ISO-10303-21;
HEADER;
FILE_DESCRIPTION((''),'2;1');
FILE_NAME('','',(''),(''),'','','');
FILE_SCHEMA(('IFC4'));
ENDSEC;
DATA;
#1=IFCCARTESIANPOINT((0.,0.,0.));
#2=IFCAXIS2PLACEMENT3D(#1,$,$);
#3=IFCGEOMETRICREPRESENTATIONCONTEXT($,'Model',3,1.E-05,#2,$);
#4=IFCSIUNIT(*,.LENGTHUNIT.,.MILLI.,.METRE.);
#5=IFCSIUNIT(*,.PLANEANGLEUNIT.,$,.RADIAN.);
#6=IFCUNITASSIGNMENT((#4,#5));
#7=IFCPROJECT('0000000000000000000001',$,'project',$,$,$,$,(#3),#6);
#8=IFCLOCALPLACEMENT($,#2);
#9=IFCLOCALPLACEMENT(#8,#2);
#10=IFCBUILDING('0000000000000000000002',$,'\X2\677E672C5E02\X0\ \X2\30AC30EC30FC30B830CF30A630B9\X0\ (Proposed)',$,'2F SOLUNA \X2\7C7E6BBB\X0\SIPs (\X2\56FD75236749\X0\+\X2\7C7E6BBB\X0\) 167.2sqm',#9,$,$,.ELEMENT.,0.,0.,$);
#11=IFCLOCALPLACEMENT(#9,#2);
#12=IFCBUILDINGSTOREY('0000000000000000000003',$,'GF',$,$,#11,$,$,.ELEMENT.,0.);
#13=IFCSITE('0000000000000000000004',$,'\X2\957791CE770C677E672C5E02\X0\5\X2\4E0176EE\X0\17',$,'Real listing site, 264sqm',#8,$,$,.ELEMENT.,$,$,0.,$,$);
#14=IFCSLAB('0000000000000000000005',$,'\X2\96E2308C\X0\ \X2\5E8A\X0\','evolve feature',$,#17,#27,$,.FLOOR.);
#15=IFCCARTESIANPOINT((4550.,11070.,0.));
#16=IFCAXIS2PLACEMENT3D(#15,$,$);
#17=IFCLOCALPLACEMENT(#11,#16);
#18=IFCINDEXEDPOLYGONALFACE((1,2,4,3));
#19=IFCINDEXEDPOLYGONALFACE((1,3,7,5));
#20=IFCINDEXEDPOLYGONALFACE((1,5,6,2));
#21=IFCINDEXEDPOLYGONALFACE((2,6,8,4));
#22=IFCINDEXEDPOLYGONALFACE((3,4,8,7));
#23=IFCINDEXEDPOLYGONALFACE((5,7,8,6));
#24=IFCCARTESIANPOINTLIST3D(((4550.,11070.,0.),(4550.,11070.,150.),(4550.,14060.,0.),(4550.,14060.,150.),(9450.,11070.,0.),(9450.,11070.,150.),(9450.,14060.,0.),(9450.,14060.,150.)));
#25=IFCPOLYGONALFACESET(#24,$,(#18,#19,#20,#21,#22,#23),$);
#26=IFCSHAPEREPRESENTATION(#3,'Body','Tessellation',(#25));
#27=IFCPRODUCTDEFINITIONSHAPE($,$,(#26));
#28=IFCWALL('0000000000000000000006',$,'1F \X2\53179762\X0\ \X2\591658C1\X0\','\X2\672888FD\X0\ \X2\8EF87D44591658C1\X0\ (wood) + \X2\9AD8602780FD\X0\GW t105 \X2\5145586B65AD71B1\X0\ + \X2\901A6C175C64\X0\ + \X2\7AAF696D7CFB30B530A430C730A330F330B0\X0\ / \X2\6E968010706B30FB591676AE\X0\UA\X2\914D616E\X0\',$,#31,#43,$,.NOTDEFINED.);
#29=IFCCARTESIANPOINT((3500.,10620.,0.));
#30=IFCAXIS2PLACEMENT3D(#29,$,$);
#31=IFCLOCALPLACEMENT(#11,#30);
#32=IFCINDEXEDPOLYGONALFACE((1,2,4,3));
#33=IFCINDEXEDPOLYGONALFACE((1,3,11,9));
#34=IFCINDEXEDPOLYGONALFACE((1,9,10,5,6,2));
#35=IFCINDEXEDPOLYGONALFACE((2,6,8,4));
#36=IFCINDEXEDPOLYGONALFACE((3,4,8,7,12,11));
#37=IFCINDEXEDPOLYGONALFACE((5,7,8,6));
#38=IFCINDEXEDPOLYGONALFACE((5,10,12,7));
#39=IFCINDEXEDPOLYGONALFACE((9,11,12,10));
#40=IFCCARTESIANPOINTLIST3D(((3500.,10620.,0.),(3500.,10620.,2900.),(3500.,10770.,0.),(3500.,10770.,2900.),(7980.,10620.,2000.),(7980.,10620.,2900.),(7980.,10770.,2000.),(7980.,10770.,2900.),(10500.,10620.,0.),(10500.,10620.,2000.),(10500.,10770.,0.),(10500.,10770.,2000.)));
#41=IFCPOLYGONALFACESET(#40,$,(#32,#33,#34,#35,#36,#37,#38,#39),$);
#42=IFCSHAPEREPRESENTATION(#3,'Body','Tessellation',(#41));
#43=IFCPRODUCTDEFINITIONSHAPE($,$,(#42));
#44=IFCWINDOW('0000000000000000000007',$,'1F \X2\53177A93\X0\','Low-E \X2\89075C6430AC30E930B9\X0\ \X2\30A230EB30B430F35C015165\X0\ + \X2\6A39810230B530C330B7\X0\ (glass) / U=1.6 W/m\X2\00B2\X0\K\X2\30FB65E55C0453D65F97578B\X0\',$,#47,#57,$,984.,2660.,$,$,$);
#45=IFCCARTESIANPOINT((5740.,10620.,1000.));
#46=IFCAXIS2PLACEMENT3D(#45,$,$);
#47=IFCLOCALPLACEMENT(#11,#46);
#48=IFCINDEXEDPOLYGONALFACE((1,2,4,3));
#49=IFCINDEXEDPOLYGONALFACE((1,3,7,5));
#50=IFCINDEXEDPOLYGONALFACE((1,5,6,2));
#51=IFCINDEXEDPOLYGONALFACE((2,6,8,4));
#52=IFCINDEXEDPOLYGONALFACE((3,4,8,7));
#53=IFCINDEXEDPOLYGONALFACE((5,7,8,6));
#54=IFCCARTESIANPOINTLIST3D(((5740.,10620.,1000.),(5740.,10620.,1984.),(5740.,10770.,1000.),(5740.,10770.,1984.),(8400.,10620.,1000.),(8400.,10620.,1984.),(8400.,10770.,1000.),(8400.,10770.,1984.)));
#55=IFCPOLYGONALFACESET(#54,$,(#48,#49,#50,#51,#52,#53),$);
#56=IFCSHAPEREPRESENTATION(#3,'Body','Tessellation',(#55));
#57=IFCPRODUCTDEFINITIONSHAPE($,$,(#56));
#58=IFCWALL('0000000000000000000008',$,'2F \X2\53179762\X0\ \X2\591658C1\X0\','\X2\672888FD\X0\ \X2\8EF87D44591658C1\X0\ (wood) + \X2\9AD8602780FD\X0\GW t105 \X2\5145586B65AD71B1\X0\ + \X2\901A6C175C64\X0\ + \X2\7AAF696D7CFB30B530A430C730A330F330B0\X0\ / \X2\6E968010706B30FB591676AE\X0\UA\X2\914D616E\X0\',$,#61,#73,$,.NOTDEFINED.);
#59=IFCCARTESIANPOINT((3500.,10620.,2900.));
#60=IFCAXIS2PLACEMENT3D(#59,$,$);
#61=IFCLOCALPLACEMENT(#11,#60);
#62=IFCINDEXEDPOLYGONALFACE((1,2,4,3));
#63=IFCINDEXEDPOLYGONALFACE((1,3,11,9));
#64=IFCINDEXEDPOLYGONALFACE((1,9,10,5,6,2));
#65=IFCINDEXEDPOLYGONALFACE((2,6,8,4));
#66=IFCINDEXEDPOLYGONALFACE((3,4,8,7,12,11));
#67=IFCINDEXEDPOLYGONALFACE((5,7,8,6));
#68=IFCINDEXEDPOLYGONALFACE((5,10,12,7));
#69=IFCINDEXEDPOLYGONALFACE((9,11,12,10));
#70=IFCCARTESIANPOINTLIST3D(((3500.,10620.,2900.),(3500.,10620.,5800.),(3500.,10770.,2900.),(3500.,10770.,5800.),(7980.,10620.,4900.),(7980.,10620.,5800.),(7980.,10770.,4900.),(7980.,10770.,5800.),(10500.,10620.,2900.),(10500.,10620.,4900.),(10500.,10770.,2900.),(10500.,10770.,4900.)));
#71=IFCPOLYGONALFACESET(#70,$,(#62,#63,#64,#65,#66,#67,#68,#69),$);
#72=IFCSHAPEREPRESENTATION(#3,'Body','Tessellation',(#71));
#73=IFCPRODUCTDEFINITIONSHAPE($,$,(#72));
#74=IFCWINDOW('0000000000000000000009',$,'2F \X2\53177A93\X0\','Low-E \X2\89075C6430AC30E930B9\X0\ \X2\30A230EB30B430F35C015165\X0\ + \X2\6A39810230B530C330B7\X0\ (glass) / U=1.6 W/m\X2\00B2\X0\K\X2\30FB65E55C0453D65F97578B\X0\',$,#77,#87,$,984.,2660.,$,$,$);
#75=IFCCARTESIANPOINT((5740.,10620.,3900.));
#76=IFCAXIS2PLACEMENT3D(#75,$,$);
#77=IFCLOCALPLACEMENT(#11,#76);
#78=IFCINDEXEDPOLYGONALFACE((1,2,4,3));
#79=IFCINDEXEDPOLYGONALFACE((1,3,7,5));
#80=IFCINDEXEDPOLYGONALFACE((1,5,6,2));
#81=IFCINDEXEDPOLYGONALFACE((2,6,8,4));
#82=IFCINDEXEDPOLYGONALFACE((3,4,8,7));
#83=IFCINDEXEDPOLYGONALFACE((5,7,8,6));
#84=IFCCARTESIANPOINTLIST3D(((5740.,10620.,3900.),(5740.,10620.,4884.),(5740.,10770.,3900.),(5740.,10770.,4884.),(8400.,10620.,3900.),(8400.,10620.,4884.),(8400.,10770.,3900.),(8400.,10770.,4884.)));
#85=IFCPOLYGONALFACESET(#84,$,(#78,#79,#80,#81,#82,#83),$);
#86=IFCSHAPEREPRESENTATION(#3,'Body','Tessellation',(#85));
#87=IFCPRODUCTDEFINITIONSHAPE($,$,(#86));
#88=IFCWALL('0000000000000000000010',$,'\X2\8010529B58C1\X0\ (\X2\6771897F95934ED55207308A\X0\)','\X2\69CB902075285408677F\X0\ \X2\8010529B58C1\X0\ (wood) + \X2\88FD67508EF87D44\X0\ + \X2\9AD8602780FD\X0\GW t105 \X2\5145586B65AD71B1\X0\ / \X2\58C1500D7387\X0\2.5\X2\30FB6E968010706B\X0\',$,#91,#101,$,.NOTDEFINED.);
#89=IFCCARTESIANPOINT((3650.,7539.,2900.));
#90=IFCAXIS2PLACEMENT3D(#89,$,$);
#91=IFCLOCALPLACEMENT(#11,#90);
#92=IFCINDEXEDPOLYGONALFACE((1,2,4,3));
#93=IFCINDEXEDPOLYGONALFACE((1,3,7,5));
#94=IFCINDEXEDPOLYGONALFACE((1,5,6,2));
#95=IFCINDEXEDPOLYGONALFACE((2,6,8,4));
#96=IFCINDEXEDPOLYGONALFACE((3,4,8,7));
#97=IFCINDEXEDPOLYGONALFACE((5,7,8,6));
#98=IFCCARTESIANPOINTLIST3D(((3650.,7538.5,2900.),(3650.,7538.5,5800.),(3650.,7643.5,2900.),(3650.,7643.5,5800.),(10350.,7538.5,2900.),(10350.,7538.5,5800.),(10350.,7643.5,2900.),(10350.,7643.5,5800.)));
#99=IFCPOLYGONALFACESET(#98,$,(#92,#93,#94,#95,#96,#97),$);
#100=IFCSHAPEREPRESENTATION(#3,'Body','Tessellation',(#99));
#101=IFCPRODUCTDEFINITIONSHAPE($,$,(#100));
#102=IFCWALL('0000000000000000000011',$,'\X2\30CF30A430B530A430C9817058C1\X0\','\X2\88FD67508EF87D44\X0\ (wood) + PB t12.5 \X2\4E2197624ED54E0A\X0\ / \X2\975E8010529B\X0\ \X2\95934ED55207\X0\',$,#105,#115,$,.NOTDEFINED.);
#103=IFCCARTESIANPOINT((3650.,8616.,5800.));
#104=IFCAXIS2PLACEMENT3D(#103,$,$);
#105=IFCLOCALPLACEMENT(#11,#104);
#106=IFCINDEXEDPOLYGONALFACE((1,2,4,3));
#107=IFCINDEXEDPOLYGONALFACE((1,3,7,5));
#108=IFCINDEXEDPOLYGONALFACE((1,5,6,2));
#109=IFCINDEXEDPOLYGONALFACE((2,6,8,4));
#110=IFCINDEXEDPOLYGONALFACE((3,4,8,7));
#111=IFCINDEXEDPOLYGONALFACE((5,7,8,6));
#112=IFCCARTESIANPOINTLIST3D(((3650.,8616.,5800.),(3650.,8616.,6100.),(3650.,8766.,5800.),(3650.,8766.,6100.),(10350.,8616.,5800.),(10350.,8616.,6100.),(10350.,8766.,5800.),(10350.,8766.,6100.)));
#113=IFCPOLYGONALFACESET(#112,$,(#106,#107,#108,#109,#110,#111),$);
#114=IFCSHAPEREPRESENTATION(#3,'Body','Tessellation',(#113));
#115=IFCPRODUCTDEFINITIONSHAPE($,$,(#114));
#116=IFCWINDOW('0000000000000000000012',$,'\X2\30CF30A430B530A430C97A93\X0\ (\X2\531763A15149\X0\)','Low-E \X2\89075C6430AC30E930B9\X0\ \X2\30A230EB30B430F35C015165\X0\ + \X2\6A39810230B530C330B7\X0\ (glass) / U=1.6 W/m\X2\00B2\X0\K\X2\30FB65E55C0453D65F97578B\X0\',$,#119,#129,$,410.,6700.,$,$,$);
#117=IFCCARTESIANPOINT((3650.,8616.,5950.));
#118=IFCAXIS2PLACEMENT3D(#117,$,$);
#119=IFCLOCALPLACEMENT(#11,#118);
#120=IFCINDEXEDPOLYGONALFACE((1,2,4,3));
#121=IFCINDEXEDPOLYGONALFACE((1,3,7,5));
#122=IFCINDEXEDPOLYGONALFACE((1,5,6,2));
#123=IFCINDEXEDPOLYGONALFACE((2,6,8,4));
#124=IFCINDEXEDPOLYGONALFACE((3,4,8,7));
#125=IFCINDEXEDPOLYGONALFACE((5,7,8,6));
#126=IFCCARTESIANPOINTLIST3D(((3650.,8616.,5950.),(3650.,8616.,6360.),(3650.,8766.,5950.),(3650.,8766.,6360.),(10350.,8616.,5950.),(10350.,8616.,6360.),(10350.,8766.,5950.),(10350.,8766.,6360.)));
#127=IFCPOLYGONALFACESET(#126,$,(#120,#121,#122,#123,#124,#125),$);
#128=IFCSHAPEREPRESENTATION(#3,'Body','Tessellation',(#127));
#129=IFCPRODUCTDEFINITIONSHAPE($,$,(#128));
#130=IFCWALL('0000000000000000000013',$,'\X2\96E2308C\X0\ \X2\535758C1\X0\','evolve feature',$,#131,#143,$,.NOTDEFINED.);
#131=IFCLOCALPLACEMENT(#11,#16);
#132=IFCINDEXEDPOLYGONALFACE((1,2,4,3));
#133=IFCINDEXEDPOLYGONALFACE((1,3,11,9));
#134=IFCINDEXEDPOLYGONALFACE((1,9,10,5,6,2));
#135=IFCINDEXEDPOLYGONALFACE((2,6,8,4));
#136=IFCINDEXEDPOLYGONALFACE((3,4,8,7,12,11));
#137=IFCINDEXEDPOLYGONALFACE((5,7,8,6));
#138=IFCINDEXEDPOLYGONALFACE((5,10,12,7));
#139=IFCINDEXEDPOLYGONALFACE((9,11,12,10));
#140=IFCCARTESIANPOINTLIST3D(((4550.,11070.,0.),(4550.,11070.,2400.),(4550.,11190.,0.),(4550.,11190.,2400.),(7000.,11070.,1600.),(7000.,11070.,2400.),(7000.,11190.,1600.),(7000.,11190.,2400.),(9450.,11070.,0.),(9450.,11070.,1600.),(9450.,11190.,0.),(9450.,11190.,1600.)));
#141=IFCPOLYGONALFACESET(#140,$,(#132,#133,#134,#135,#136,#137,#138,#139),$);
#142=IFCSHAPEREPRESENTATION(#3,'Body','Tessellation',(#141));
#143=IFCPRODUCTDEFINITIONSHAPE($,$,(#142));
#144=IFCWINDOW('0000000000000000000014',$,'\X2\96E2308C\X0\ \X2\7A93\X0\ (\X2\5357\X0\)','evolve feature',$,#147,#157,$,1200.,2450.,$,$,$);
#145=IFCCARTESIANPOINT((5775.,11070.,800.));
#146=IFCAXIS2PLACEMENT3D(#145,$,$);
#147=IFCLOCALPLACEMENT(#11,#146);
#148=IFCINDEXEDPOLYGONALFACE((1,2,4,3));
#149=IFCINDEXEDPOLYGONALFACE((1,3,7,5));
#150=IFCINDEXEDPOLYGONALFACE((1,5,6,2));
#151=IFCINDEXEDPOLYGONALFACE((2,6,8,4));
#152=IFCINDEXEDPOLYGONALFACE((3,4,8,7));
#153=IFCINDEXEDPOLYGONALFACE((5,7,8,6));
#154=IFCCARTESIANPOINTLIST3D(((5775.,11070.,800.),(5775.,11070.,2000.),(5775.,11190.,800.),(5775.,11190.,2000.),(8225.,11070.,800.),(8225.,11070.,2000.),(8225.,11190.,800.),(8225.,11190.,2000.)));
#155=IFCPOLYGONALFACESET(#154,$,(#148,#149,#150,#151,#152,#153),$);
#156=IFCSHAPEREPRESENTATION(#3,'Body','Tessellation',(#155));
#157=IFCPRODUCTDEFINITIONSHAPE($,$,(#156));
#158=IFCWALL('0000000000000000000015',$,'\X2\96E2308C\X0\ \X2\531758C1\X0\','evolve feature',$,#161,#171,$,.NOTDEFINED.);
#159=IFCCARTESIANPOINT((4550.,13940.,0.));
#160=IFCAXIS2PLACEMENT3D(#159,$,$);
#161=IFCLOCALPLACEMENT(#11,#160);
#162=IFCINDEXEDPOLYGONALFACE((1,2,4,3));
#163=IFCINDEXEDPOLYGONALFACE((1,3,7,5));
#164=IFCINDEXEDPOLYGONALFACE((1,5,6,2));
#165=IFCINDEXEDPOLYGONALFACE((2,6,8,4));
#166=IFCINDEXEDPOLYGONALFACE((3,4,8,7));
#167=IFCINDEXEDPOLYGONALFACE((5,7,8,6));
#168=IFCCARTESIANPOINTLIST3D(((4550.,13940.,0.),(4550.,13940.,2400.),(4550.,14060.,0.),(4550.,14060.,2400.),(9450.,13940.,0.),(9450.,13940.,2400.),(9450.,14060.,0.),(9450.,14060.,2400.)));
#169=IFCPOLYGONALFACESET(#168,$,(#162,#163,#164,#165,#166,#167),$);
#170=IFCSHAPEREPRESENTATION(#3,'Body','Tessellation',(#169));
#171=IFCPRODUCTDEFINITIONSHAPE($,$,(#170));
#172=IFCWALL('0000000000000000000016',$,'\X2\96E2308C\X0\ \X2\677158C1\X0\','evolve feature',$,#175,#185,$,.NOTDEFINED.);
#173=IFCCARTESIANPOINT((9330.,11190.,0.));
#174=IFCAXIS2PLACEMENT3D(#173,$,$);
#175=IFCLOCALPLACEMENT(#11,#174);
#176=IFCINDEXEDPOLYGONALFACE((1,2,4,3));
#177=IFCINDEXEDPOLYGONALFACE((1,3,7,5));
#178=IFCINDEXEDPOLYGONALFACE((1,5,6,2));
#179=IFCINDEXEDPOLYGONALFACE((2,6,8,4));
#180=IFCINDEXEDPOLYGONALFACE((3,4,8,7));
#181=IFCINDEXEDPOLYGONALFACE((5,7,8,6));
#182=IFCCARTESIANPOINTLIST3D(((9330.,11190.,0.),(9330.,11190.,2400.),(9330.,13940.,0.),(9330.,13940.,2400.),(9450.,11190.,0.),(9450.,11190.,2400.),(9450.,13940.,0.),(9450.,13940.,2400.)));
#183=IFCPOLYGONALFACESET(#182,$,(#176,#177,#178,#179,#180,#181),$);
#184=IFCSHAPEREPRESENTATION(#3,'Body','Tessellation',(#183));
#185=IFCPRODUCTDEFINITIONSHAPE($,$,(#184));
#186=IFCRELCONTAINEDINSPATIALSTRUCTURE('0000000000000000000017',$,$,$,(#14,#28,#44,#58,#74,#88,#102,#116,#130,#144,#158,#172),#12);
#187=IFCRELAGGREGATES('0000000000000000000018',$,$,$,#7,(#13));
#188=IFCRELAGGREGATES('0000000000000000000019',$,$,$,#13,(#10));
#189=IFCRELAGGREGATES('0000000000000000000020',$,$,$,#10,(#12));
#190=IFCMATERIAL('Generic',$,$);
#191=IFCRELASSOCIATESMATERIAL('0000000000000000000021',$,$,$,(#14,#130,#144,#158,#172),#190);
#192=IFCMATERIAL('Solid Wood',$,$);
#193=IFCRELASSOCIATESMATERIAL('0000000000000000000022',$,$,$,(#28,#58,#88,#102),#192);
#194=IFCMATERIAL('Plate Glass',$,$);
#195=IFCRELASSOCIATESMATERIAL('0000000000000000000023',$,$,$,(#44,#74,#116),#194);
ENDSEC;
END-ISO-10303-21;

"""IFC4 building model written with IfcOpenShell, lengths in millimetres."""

from ifc_helpers import new_model, si_unit, frame, frame_2d, origin, place, context, project, spatial, rectangle, extrude, material, element, fill, save


model = new_model("IFC4")

# Units and contexts
model_context = context("Model", 3, precision=1e-05, world=origin())
ifc_project = project(units=[si_unit("LENGTHUNIT", "METRE", prefix="MILLI"), si_unit("PLANEANGLEUNIT", "RADIAN")], contexts=[model_context])

# Site, building, storey
site_placement = place(None, origin())
site = spatial("IfcSite", under=ifc_project, at=site_placement, Name="長野県松本市5丁目17", ObjectType="Real listing site, 264sqm", CompositionType="ELEMENT", RefElevation=0.0)
building_placement = place(site_placement, origin())
building = spatial("IfcBuilding", under=site, at=building_placement, Name="松本市 ガレージハウス (Proposed)", ObjectType="2F SOLUNA 籾殻SIPs (国産杉+籾殻) 167.2sqm", CompositionType="ELEMENT", ElevationOfRefHeight=0.0, ElevationOfTerrain=0.0)
storey_placement = place(building_placement, origin())
storey = spatial("IfcBuildingStorey", under=building, at=storey_placement, Name="GF", CompositionType="ELEMENT", Elevation=0.0)

# Slab
ifc_material_1 = material(Name="Generic")
slab_placement = place(storey_placement, frame((4550.0, 11070.0, 0.0)))
element("IfcSlab", 1, at=slab_placement, inside=storey, material=ifc_material_1, Name="離れ 床", Description="evolve feature", PredefinedType="FLOOR", context=model_context, shape_type="SweptSolid", body=[
    extrude(rectangle(XDim=4900.0, YDim=2990.0, at=frame_2d((2450.0, 1495.0))), frame((4550.0, 11070.0, 0.0)), (0.0, 0.0, 1.0), 150.0),
])

# Wall, opening, window
ifc_material_2 = material(Name="Solid Wood")
wall_1_placement = place(storey_placement, frame((3500.0, 10620.0, 0.0)))
wall_1 = element("IfcWall", 2, at=wall_1_placement, inside=storey, material=ifc_material_2, Name="1F 北面 外壁", Description="木製 軸組外壁 (wood) + 高性能GW t105 充填断熱 + 通気層 + 窯業系サイディング / 準耐火・外皮UA配慮", PredefinedType="NOTDEFINED", context=model_context, shape_type="SweptSolid", body=[
    extrude(rectangle(XDim=7000.0, YDim=150.0, at=frame_2d((3500.0, 75.0))), frame((3500.0, 10620.0, 0.0)), (0.0, 0.0, 1.0), 2900.0),
])
opening_1_placement = place(storey_placement, frame((5740.0, 10620.0, 1000.0)))
opening_1 = element("IfcOpeningElement", 3, at=opening_1_placement, cuts=wall_1, PredefinedType="NOTDEFINED", context=model_context, shape_type="SweptSolid", body=[
    extrude(rectangle(XDim=2660.0, YDim=150.0, at=frame_2d((1330.0, 75.0))), frame((5740.0, 10620.0, 1000.0)), (0.0, 0.0, 1.0), 984.0),
])
ifc_material_3 = material(Name="Plate Glass")
window_1_placement = place(storey_placement, frame((5740.0, 10620.0, 1000.0)))
window_1 = element("IfcWindow", 4, at=window_1_placement, inside=storey, material=ifc_material_3, Name="1F 北窓", Description="Low-E 複層ガラス アルゴン封入 + 樹脂サッシ (glass) / U=1.6 W/m²K・日射取得型", OverallHeight=984.0, OverallWidth=2660.0, context=model_context, shape_type="SweptSolid", body=[
    extrude(rectangle(XDim=2660.0, YDim=150.0, at=frame_2d((1330.0, 75.0))), frame((5740.0, 10620.0, 1000.0)), (0.0, 0.0, 1.0), 984.0),
])
fill(opening_1, window_1)

# Wall, opening, window
wall_2_placement = place(storey_placement, frame((3500.0, 10620.0, 2900.0)))
wall_2 = element("IfcWall", 5, at=wall_2_placement, inside=storey, material=ifc_material_2, Name="2F 北面 外壁", Description="木製 軸組外壁 (wood) + 高性能GW t105 充填断熱 + 通気層 + 窯業系サイディング / 準耐火・外皮UA配慮", PredefinedType="NOTDEFINED", context=model_context, shape_type="SweptSolid", body=[
    extrude(rectangle(XDim=7000.0, YDim=150.0, at=frame_2d((3500.0, 75.0))), frame((3500.0, 10620.0, 2900.0)), (0.0, 0.0, 1.0), 2900.0),
])
opening_2_placement = place(storey_placement, frame((5740.0, 10620.0, 3900.0)))
opening_2 = element("IfcOpeningElement", 6, at=opening_2_placement, cuts=wall_2, PredefinedType="NOTDEFINED", context=model_context, shape_type="SweptSolid", body=[
    extrude(rectangle(XDim=2660.0, YDim=150.0, at=frame_2d((1330.0, 75.0))), frame((5740.0, 10620.0, 3900.0)), (0.0, 0.0, 1.0), 984.0),
])
window_2_placement = place(storey_placement, frame((5740.0, 10620.0, 3900.0)))
window_2 = element("IfcWindow", 7, at=window_2_placement, inside=storey, material=ifc_material_3, Name="2F 北窓", Description="Low-E 複層ガラス アルゴン封入 + 樹脂サッシ (glass) / U=1.6 W/m²K・日射取得型", OverallHeight=984.0, OverallWidth=2660.0, context=model_context, shape_type="SweptSolid", body=[
    extrude(rectangle(XDim=2660.0, YDim=150.0, at=frame_2d((1330.0, 75.0))), frame((5740.0, 10620.0, 3900.0)), (0.0, 0.0, 1.0), 984.0),
])
fill(opening_2, window_2)

# Wall
wall_3_placement = place(storey_placement, frame((3650.0, 7539.0, 2900.0)))
element("IfcWall", 8, at=wall_3_placement, inside=storey, material=ifc_material_2, Name="耐力壁 (東西間仕切り)", Description="構造用合板 耐力壁 (wood) + 製材軸組 + 高性能GW t105 充填断熱 / 壁倍率2.5・準耐火", PredefinedType="NOTDEFINED", context=model_context, shape_type="SweptSolid", body=[
    extrude(rectangle(XDim=6700.0, YDim=105.0, at=frame_2d((3350.0, 52.0))), frame((3650.0, 7539.0, 2900.0)), (0.0, 0.0, 1.0), 2900.0),
])

# Walls, openings, windows
wall_4_placement = place(storey_placement, frame((3650.0, 8616.0, 5800.0)))
wall_4 = element("IfcWall", 9, at=wall_4_placement, inside=storey, material=ifc_material_2, Name="ハイサイド腰壁", Description="製材軸組 (wood) + PB t12.5 両面仕上 / 非耐力 間仕切", PredefinedType="NOTDEFINED", context=model_context, shape_type="SweptSolid", body=[
    extrude(rectangle(XDim=6700.0, YDim=150.0, at=frame_2d((3350.0, 75.0))), frame((3650.0, 8616.0, 5800.0)), (0.0, 0.0, 1.0), 700.0),
])
opening_3_placement = place(storey_placement, frame((3650.0, 8616.0, 5950.0)))
opening_3 = element("IfcOpeningElement", 10, at=opening_3_placement, cuts=wall_4, PredefinedType="NOTDEFINED", context=model_context, shape_type="SweptSolid", body=[
    extrude(rectangle(XDim=6700.0, YDim=150.0, at=frame_2d((3350.0, 75.0))), frame((3650.0, 8616.0, 5950.0)), (0.0, 0.0, 1.0), 410.0),
])
window_3_placement = place(storey_placement, frame((3650.0, 8616.0, 5950.0)))
window_3 = element("IfcWindow", 11, at=window_3_placement, inside=storey, material=ifc_material_3, Name="ハイサイド窓 (北採光)", Description="Low-E 複層ガラス アルゴン封入 + 樹脂サッシ (glass) / U=1.6 W/m²K・日射取得型", OverallHeight=410.0, OverallWidth=6700.0, context=model_context, shape_type="SweptSolid", body=[
    extrude(rectangle(XDim=6700.0, YDim=150.0, at=frame_2d((3350.0, 75.0))), frame((3650.0, 8616.0, 5950.0)), (0.0, 0.0, 1.0), 410.0),
])
fill(opening_3, window_3)
wall_5_placement = place(storey_placement, frame((4550.0, 11070.0, 0.0)))
wall_5 = element("IfcWall", 12, at=wall_5_placement, inside=storey, material=ifc_material_1, Name="離れ 南壁", Description="evolve feature", PredefinedType="NOTDEFINED", context=model_context, shape_type="SweptSolid", body=[
    extrude(rectangle(XDim=4900.0, YDim=120.0, at=frame_2d((2450.0, 60.0))), frame((4550.0, 11070.0, 0.0)), (0.0, 0.0, 1.0), 2400.0),
])
opening_4_placement = place(storey_placement, frame((5775.0, 11070.0, 800.0)))
opening_4 = element("IfcOpeningElement", 13, at=opening_4_placement, cuts=wall_5, PredefinedType="NOTDEFINED", context=model_context, shape_type="SweptSolid", body=[
    extrude(rectangle(XDim=2450.0, YDim=120.0, at=frame_2d((1225.0, 60.0))), frame((5775.0, 11070.0, 800.0)), (0.0, 0.0, 1.0), 1200.0),
])
window_4_placement = place(storey_placement, frame((5775.0, 11070.0, 800.0)))
window_4 = element("IfcWindow", 14, at=window_4_placement, inside=storey, material=ifc_material_1, Name="離れ 窓 (南)", Description="evolve feature", OverallHeight=1200.0, OverallWidth=2450.0, context=model_context, shape_type="SweptSolid", body=[
    extrude(rectangle(XDim=2450.0, YDim=120.0, at=frame_2d((1225.0, 60.0))), frame((5775.0, 11070.0, 800.0)), (0.0, 0.0, 1.0), 1200.0),
])
fill(opening_4, window_4)

# Walls
wall_6_placement = place(storey_placement, frame((4550.0, 13940.0, 0.0)))
element("IfcWall", 15, at=wall_6_placement, inside=storey, material=ifc_material_1, Name="離れ 北壁", Description="evolve feature", PredefinedType="NOTDEFINED", context=model_context, shape_type="SweptSolid", body=[
    extrude(rectangle(XDim=4900.0, YDim=120.0, at=frame_2d((2450.0, 60.0))), frame((4550.0, 13940.0, 0.0)), (0.0, 0.0, 1.0), 2400.0),
])
wall_7_placement = place(storey_placement, frame((9330.0, 11190.0, 0.0)))
element("IfcWall", 16, at=wall_7_placement, inside=storey, material=ifc_material_1, Name="離れ 東壁", Description="evolve feature", PredefinedType="NOTDEFINED", context=model_context, shape_type="SweptSolid", body=[
    extrude(rectangle(XDim=120.0, YDim=2750.0, at=frame_2d((60.0, 1375.0))), frame((9330.0, 11190.0, 0.0)), (0.0, 0.0, 1.0), 2400.0),
])

save(model, "model.ifc")
